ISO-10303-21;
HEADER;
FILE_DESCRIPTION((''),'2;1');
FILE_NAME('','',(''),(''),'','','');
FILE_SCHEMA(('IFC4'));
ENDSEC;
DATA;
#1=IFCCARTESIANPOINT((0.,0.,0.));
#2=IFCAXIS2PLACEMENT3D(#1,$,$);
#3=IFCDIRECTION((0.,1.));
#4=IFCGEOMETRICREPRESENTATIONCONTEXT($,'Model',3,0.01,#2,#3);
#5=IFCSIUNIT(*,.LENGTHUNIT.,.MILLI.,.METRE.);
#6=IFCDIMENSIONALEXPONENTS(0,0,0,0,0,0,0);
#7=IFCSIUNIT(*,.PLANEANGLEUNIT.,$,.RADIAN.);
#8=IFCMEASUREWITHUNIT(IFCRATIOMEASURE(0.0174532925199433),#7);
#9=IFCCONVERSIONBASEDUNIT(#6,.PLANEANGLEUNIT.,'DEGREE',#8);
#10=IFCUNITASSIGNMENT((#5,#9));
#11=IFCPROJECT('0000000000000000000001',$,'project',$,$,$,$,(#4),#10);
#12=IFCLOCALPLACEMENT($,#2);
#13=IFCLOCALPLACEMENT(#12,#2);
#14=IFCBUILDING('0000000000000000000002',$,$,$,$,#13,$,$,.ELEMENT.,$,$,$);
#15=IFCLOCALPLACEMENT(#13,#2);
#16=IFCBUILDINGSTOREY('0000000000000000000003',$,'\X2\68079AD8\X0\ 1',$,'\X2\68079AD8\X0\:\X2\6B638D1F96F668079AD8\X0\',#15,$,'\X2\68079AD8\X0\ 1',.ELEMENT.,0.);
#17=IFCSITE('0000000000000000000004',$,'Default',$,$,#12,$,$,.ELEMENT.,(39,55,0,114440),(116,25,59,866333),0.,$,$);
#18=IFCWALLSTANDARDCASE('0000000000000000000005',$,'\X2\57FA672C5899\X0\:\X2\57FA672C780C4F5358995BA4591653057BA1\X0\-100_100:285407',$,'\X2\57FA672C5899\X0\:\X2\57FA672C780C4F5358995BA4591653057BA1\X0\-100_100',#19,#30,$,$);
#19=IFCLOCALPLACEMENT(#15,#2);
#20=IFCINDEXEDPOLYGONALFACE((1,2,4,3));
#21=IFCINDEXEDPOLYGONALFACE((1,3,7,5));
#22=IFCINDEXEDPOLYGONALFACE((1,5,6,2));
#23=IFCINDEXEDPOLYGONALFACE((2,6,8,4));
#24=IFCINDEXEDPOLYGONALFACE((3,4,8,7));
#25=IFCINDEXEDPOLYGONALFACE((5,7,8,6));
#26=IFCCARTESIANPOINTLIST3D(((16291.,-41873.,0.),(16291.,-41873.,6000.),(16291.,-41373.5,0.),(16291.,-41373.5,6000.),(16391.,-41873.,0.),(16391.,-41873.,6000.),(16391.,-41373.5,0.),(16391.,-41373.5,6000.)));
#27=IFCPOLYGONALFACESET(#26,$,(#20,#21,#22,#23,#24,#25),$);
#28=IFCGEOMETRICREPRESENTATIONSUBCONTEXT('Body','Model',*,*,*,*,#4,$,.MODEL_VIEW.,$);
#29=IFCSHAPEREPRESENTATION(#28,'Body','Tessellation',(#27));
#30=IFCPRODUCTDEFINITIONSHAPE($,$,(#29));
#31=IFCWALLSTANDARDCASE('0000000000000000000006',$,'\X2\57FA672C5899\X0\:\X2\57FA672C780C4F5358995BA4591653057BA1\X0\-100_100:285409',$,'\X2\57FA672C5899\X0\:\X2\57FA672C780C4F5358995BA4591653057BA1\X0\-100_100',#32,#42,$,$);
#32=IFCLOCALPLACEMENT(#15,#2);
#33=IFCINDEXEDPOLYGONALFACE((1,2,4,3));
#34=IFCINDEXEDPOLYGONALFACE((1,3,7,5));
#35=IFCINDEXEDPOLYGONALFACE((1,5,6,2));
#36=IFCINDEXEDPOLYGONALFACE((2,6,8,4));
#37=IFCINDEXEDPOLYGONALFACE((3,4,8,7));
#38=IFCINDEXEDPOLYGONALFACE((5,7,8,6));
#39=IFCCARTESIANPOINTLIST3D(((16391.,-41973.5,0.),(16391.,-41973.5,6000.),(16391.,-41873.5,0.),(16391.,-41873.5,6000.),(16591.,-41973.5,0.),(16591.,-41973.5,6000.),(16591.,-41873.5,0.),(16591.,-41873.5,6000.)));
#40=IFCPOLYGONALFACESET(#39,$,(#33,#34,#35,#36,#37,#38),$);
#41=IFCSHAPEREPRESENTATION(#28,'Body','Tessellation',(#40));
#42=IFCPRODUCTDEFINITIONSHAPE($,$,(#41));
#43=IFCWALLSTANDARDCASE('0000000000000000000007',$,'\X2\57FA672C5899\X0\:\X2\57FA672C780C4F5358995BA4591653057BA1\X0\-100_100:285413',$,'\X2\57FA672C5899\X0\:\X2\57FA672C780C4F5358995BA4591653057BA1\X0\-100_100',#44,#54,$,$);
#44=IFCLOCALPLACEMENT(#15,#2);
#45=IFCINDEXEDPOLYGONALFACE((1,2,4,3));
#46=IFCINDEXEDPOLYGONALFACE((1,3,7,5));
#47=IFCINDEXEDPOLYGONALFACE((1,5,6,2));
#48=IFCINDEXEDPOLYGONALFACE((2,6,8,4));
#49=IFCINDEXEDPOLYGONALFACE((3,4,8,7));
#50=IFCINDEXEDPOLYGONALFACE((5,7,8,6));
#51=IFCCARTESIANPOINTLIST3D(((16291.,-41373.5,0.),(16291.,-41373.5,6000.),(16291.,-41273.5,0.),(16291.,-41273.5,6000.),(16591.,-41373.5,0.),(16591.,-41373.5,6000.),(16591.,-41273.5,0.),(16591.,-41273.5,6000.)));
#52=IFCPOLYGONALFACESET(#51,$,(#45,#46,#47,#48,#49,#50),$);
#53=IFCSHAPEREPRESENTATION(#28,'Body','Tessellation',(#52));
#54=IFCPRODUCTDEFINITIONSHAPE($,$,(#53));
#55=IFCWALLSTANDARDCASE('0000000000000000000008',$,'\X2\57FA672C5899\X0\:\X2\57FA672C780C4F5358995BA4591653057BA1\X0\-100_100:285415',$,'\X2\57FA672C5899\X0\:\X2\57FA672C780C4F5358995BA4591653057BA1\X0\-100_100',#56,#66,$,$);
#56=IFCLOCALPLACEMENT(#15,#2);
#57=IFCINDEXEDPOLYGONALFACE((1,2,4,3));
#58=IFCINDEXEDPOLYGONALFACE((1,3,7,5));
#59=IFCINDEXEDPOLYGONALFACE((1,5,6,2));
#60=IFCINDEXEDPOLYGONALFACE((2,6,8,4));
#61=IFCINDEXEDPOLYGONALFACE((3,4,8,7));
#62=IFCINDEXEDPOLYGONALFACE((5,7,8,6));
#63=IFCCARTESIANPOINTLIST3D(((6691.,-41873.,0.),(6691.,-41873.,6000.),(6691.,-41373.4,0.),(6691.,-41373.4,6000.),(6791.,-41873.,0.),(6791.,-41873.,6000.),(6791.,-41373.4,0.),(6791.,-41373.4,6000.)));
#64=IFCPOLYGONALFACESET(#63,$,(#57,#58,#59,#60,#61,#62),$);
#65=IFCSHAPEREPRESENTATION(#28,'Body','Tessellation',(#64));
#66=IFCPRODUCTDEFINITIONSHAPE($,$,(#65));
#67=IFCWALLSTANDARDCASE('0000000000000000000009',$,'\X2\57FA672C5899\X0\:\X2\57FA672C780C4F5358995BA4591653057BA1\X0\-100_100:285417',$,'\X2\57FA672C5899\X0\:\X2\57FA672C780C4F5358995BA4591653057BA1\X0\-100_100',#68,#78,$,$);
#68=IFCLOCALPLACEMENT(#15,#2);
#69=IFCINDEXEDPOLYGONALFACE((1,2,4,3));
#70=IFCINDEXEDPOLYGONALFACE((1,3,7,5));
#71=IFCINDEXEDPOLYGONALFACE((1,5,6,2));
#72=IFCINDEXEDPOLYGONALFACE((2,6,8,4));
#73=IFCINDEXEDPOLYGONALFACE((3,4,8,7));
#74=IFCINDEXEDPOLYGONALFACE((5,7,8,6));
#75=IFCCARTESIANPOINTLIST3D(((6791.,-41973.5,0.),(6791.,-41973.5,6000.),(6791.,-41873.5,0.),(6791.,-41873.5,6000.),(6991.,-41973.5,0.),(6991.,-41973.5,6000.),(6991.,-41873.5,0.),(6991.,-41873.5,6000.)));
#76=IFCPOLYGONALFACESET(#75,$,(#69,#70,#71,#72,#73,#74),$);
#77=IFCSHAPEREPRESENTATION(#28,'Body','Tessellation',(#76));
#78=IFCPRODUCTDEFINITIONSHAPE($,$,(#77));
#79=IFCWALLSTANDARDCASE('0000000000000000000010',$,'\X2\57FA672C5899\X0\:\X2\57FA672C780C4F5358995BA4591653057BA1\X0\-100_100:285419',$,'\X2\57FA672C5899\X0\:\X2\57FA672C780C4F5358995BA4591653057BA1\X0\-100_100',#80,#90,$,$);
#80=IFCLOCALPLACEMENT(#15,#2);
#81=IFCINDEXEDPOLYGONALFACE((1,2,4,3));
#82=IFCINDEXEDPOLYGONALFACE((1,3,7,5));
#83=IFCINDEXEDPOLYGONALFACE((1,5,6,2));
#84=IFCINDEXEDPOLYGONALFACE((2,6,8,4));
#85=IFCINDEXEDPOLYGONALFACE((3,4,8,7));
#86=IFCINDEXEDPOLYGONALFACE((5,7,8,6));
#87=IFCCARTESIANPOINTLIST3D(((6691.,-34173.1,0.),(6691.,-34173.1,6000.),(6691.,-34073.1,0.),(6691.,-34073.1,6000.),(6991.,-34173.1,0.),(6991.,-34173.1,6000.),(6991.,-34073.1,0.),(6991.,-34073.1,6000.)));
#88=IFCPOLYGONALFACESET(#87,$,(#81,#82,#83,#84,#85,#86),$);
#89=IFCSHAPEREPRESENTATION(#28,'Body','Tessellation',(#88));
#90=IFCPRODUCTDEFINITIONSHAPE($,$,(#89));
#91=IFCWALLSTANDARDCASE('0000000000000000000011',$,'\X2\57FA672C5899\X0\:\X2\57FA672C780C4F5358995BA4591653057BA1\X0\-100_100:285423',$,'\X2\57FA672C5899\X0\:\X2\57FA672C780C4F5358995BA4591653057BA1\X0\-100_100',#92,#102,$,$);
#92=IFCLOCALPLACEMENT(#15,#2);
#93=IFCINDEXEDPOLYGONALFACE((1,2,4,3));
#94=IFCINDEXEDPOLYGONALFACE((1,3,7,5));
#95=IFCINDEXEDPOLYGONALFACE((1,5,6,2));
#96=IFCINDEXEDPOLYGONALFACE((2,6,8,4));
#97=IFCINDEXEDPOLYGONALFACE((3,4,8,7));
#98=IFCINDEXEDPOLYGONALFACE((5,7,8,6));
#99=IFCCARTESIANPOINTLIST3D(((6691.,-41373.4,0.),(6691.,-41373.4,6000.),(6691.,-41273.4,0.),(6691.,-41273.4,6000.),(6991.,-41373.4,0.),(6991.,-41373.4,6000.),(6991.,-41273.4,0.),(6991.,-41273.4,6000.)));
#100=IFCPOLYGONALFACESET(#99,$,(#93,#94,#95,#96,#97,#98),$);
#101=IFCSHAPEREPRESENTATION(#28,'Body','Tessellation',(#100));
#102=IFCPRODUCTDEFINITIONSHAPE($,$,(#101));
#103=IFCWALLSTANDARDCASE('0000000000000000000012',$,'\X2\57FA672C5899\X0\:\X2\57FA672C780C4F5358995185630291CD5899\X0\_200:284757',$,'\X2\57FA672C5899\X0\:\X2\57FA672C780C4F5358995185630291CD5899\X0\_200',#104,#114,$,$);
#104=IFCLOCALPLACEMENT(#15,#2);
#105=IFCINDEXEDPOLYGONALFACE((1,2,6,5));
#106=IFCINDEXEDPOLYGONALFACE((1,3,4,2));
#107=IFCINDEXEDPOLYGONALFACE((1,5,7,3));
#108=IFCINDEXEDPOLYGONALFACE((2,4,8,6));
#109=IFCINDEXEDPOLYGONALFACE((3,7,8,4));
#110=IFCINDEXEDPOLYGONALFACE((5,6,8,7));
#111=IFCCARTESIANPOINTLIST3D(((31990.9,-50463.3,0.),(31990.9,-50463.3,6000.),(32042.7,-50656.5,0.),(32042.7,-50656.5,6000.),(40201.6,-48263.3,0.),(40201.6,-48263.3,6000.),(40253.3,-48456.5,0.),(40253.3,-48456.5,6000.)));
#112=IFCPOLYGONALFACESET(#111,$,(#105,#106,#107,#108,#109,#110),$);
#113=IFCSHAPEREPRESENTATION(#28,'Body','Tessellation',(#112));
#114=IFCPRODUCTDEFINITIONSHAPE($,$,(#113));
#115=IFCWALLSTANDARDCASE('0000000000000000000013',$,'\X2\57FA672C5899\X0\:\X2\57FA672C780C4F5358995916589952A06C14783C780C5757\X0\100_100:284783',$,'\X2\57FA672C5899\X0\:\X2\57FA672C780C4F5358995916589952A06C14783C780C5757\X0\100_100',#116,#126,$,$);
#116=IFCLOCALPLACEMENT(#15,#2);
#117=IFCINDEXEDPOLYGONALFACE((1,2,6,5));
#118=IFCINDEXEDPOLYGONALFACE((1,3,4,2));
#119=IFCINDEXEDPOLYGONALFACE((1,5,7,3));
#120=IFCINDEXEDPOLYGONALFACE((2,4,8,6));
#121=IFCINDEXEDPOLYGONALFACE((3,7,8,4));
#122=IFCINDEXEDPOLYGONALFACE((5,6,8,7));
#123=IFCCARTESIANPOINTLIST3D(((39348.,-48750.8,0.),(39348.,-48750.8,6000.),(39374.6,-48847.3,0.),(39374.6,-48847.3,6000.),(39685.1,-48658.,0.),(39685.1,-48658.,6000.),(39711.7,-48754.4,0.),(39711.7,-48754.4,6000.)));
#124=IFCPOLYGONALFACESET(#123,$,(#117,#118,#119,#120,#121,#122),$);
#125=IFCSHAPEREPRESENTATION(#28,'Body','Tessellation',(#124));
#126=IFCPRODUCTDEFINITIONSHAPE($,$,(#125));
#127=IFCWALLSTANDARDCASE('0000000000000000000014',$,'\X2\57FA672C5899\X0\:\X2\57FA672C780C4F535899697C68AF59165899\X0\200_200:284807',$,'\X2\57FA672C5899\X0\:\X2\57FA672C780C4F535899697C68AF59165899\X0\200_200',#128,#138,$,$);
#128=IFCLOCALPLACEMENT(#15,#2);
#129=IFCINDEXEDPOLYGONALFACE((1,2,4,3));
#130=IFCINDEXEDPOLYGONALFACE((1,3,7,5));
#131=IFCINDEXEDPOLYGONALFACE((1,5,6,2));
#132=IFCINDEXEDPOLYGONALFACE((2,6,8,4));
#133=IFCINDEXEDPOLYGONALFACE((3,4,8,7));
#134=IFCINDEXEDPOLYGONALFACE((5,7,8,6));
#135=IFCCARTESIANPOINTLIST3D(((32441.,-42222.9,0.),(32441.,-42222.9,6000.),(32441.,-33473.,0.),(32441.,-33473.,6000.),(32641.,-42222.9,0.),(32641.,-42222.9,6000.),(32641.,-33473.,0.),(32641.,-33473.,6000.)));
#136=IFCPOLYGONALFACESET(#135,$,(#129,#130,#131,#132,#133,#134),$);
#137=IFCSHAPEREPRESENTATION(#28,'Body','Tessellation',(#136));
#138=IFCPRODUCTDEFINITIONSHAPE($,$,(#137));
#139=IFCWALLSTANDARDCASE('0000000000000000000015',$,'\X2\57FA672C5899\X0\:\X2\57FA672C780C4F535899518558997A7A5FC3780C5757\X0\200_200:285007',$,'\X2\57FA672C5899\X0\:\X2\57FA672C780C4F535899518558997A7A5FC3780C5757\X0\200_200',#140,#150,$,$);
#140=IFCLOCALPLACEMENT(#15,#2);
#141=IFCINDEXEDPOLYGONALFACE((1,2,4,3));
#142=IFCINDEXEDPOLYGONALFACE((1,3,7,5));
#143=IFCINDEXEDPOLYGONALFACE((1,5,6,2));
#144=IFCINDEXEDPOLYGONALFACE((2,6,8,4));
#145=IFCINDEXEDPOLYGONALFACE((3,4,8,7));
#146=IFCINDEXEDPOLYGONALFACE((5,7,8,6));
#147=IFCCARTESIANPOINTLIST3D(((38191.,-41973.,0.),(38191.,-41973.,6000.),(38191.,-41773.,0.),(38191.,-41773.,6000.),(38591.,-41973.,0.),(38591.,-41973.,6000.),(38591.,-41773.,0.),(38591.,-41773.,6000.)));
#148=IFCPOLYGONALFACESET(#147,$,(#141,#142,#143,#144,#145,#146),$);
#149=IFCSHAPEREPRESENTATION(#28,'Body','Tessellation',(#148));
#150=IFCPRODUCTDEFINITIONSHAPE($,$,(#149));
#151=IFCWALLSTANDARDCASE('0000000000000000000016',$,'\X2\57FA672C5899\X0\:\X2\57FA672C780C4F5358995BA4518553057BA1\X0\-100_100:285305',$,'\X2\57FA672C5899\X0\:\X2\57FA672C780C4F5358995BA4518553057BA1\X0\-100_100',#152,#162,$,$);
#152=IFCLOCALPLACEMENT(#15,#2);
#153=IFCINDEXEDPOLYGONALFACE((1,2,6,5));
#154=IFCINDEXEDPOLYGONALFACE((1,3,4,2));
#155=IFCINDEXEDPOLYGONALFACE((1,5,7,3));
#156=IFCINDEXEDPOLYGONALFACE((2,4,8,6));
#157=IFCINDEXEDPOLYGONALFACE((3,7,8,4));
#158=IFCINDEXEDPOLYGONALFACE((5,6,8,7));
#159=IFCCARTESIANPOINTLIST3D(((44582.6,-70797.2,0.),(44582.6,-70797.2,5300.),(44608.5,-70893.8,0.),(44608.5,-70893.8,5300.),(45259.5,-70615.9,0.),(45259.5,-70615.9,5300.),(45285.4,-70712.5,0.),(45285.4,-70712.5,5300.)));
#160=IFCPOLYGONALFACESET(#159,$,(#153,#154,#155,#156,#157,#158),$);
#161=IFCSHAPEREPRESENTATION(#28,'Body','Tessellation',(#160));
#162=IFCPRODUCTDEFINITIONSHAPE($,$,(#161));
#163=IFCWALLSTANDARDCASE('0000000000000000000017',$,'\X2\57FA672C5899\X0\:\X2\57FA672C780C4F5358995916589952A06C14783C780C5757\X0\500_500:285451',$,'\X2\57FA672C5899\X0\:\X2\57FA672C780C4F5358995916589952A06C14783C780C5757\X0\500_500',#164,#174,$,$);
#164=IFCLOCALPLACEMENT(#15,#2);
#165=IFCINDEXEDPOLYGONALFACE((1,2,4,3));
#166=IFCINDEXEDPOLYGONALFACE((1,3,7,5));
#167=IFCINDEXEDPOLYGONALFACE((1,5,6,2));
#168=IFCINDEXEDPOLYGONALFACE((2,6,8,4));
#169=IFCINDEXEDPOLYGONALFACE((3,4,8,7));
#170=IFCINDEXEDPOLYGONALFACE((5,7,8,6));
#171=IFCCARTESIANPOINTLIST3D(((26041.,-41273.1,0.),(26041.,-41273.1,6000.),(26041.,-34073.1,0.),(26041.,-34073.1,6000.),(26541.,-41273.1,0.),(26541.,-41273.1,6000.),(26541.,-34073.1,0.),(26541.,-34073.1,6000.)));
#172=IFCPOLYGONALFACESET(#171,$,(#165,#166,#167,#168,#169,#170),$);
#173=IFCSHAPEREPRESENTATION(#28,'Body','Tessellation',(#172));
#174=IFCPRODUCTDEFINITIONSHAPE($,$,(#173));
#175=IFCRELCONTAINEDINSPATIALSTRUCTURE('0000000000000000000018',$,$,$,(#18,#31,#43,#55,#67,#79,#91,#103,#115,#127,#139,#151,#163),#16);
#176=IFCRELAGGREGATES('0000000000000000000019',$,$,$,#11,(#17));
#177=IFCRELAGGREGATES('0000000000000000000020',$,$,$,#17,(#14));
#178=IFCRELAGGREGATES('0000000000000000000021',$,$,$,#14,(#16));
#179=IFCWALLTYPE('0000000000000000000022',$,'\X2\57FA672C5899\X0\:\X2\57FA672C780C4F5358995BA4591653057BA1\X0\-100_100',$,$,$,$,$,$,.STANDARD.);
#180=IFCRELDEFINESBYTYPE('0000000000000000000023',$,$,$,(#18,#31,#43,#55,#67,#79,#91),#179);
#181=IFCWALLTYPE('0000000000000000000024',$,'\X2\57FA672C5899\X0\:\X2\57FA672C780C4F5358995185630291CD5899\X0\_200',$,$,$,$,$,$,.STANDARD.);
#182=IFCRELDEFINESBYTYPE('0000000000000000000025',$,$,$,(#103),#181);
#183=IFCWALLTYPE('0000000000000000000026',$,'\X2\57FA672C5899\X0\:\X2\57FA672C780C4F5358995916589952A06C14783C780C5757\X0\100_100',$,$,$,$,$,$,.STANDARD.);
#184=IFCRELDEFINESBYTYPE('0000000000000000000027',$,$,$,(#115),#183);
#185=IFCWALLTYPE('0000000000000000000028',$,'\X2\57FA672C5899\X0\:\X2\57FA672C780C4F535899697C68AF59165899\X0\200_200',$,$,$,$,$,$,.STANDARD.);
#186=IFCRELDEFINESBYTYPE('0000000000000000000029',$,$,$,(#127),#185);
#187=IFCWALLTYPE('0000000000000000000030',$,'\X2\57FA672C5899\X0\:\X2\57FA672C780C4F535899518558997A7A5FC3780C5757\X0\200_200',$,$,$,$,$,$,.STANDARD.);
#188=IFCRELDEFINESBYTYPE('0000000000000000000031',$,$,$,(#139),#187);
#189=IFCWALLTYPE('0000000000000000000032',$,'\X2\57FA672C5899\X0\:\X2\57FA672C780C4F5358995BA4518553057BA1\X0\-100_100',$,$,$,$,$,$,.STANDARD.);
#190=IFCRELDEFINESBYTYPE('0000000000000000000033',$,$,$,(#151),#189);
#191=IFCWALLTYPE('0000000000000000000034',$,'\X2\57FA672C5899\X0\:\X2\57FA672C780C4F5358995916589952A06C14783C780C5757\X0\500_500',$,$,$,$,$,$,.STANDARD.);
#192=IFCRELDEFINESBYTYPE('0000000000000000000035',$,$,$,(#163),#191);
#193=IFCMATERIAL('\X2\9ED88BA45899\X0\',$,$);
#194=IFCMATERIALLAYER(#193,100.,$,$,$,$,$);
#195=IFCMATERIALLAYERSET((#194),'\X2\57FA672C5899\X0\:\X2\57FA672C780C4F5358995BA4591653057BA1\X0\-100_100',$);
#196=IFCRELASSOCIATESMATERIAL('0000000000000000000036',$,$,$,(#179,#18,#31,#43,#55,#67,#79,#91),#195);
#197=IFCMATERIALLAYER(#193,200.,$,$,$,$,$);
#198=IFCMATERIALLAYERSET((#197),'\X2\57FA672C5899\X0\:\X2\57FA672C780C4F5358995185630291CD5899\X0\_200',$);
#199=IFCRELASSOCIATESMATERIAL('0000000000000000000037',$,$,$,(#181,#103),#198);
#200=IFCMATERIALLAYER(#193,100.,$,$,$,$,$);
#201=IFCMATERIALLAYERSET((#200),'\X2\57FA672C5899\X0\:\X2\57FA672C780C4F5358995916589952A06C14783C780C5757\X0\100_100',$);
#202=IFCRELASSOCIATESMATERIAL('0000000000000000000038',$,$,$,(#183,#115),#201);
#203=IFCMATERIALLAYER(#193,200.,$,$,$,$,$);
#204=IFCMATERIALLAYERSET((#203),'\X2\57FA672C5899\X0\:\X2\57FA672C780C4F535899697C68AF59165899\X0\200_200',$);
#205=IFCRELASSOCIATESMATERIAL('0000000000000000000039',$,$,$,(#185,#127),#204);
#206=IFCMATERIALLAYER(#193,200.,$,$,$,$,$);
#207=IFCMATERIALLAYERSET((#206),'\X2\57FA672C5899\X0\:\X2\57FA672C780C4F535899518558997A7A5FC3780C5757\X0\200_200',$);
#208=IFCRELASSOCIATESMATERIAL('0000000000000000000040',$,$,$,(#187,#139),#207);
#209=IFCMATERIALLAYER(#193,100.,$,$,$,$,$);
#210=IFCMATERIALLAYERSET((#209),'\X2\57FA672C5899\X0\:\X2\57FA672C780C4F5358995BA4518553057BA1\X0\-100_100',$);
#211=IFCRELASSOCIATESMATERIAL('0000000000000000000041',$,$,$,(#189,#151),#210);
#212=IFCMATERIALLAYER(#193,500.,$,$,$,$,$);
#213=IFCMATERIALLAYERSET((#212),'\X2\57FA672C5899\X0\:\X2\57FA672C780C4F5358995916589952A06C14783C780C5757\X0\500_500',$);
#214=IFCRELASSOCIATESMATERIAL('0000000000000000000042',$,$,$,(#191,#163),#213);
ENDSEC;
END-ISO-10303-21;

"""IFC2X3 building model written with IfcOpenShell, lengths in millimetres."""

from ifc_helpers import new_model, entity, si_unit, converted_unit, direction, frame, frame_2d, origin, place, context, subcontext, project, spatial, rectangle, extrude, material, layer, layer_set, layer_usage, type_object, element, save


model = new_model("IFC2X3")

# Units and contexts
model_context = context("Model", 3, precision=0.01, world=origin(), true_north=direction((0.0, 1.0)))
body_context = subcontext(model_context, "Body", "Model", "MODEL_VIEW")
ifc_project = project(units=[si_unit("LENGTHUNIT", "METRE", prefix="MILLI"), converted_unit("PLANEANGLEUNIT", "DEGREE", entity("IfcRatioMeasure", 0.0174532925199433), si_unit("PLANEANGLEUNIT", "RADIAN"), dimensions=[0, 0, 0, 0, 0, 0, 0])], contexts=[model_context])

# Site, building, storey
site_placement = place(None, origin())
site = spatial("IfcSite", under=ifc_project, at=site_placement, Name="Default", CompositionType="ELEMENT", RefLatitude=(39, 55, 0, 114440), RefLongitude=(116, 25, 59, 866333), RefElevation=0.0)
building_placement = place(site_placement, origin())
building = spatial("IfcBuilding", under=site, at=building_placement, CompositionType="ELEMENT")
storey_placement = place(building_placement, origin())
storey = spatial("IfcBuildingStorey", under=building, at=storey_placement, Name="标高 1", ObjectType="标高:正负零标高", LongName="标高 1", CompositionType="ELEMENT", Elevation=0.0)

# Walls
ifc_material = material(Name="默认墙")
ifc_layer_1 = layer(ifc_material, 100.0)
ifc_layer_set_1 = layer_set([ifc_layer_1], Name="基本墙:基本砌体墙室外包管-100_100")
wall_type_1 = type_object("IfcWallType", Name="基本墙:基本砌体墙室外包管-100_100", PredefinedType="STANDARD", material=ifc_layer_set_1)
ifc_layer_usage_1 = layer_usage(ifc_layer_set_1, "AXIS2", "NEGATIVE", 50.0)
wall_1_placement = place(building_placement, frame((16341.0, -41373.5, 0.0), z_axis=(0.0, 0.0, 1.0), x_axis=(0.0, -1.0, 0.0)))
element("IfcWallStandardCase", 1, at=wall_1_placement, inside=storey, type_object=wall_type_1, material=ifc_layer_usage_1, Name="基本墙:基本砌体墙室外包管-100_100:285407", ObjectType="基本墙:基本砌体墙室外包管-100_100", context=body_context, shape_type="SweptSolid", body=[
    extrude(rectangle(XDim=499.5, YDim=100.0, at=frame_2d((249.8, 0.0), x_axis=(-1.0, 0.0))), origin(), (0.0, 0.0, 1.0), 6000.0),
])
ifc_layer_usage_2 = layer_usage(ifc_layer_set_1, "AXIS2", "NEGATIVE", 50.0)
wall_2_placement = place(building_placement, frame((16391.0, -41923.5, 0.0)))
element("IfcWallStandardCase", 2, at=wall_2_placement, inside=storey, type_object=wall_type_1, material=ifc_layer_usage_2, Name="基本墙:基本砌体墙室外包管-100_100:285409", ObjectType="基本墙:基本砌体墙室外包管-100_100", context=body_context, shape_type="SweptSolid", body=[
    extrude(rectangle(XDim=200.0, YDim=100.0, at=frame_2d((100.0, 0.0), x_axis=(-1.0, 0.0))), origin(), (0.0, 0.0, 1.0), 6000.0),
])
ifc_layer_usage_3 = layer_usage(ifc_layer_set_1, "AXIS2", "NEGATIVE", 50.0)
wall_3_placement = place(building_placement, frame((16291.0, -41323.5, 0.0)))
element("IfcWallStandardCase", 3, at=wall_3_placement, inside=storey, type_object=wall_type_1, material=ifc_layer_usage_3, Name="基本墙:基本砌体墙室外包管-100_100:285413", ObjectType="基本墙:基本砌体墙室外包管-100_100", context=body_context, shape_type="SweptSolid", body=[
    extrude(rectangle(XDim=300.0, YDim=100.0, at=frame_2d((150.0, 0.0), x_axis=(-1.0, 0.0))), origin(), (0.0, 0.0, 1.0), 6000.0),
])
ifc_layer_usage_4 = layer_usage(ifc_layer_set_1, "AXIS2", "NEGATIVE", 50.0)
wall_4_placement = place(building_placement, frame((6741.0, -41373.4, 0.0), z_axis=(0.0, 0.0, 1.0), x_axis=(0.0, -1.0, 0.0)))
element("IfcWallStandardCase", 4, at=wall_4_placement, inside=storey, type_object=wall_type_1, material=ifc_layer_usage_4, Name="基本墙:基本砌体墙室外包管-100_100:285415", ObjectType="基本墙:基本砌体墙室外包管-100_100", context=body_context, shape_type="SweptSolid", body=[
    extrude(rectangle(XDim=499.6, YDim=100.0, at=frame_2d((249.8, 0.0), x_axis=(-1.0, 0.0))), origin(), (0.0, 0.0, 1.0), 6000.0),
])
ifc_layer_usage_5 = layer_usage(ifc_layer_set_1, "AXIS2", "NEGATIVE", 50.0)
wall_5_placement = place(building_placement, frame((6791.0, -41923.5, 0.0)))
element("IfcWallStandardCase", 5, at=wall_5_placement, inside=storey, type_object=wall_type_1, material=ifc_layer_usage_5, Name="基本墙:基本砌体墙室外包管-100_100:285417", ObjectType="基本墙:基本砌体墙室外包管-100_100", context=body_context, shape_type="SweptSolid", body=[
    extrude(rectangle(XDim=200.0, YDim=100.0, at=frame_2d((100.0, 0.0), x_axis=(-1.0, 0.0))), origin(), (0.0, 0.0, 1.0), 6000.0),
])
ifc_layer_usage_6 = layer_usage(ifc_layer_set_1, "AXIS2", "NEGATIVE", 50.0)
wall_6_placement = place(building_placement, frame((6691.0, -34123.1, 0.0)))
element("IfcWallStandardCase", 6, at=wall_6_placement, inside=storey, type_object=wall_type_1, material=ifc_layer_usage_6, Name="基本墙:基本砌体墙室外包管-100_100:285419", ObjectType="基本墙:基本砌体墙室外包管-100_100", context=body_context, shape_type="SweptSolid", body=[
    extrude(rectangle(XDim=300.0, YDim=100.0, at=frame_2d((150.0, 0.0), x_axis=(-1.0, 0.0))), origin(), (0.0, 0.0, 1.0), 6000.0),
])
ifc_layer_usage_7 = layer_usage(ifc_layer_set_1, "AXIS2", "NEGATIVE", 50.0)
wall_7_placement = place(building_placement, frame((6691.0, -41323.4, 0.0)))
element("IfcWallStandardCase", 7, at=wall_7_placement, inside=storey, type_object=wall_type_1, material=ifc_layer_usage_7, Name="基本墙:基本砌体墙室外包管-100_100:285423", ObjectType="基本墙:基本砌体墙室外包管-100_100", context=body_context, shape_type="SweptSolid", body=[
    extrude(rectangle(XDim=300.0, YDim=100.0, at=frame_2d((150.0, 0.0), x_axis=(-1.0, 0.0))), origin(), (0.0, 0.0, 1.0), 6000.0),
])
ifc_layer_2 = layer(ifc_material, 200.0)
ifc_layer_set_2 = layer_set([ifc_layer_2], Name="基本墙:基本砌体墙内挂重墙_200")
ifc_layer_usage_8 = layer_usage(ifc_layer_set_2, "AXIS2", "NEGATIVE", 100.0)
wall_type_2 = type_object("IfcWallType", Name="基本墙:基本砌体墙内挂重墙_200", PredefinedType="STANDARD", material=ifc_layer_set_2)
wall_8_placement = place(building_placement, frame((32016.8, -50559.9, 0.0), z_axis=(0.0, 0.0, 1.0), x_axis=(0.965926, 0.258819, 0.0)))
element("IfcWallStandardCase", 8, at=wall_8_placement, inside=storey, type_object=wall_type_2, material=ifc_layer_usage_8, Name="基本墙:基本砌体墙内挂重墙_200:284757", ObjectType="基本墙:基本砌体墙内挂重墙_200", context=body_context, shape_type="SweptSolid", body=[
    extrude(rectangle(XDim=8500.3, YDim=200.0, at=frame_2d((4250.1, 0.0), x_axis=(-1.0, 0.0))), origin(), (0.0, 0.0, 1.0), 6000.0),
])
ifc_layer_3 = layer(ifc_material, 100.0)
ifc_layer_set_3 = layer_set([ifc_layer_3], Name="基本墙:基本砌体墙外墙加气砼砌块100_100")
ifc_layer_usage_9 = layer_usage(ifc_layer_set_3, "AXIS2", "NEGATIVE", 50.0)
wall_type_3 = type_object("IfcWallType", Name="基本墙:基本砌体墙外墙加气砼砌块100_100", PredefinedType="STANDARD", material=ifc_layer_set_3)
wall_9_placement = place(building_placement, frame((39361.3, -48799.0, 0.0), z_axis=(0.0, 0.0, 1.0), x_axis=(0.964054, 0.265705, 0.0)))
element("IfcWallStandardCase", 9, at=wall_9_placement, inside=storey, type_object=wall_type_3, material=ifc_layer_usage_9, Name="基本墙:基本砌体墙外墙加气砼砌块100_100:284783", ObjectType="基本墙:基本砌体墙外墙加气砼砌块100_100", context=body_context, shape_type="SweptSolid", body=[
    extrude(rectangle(XDim=349.6, YDim=100.0, at=frame_2d((174.8, 0.0), x_axis=(-1.0, 0.0))), origin(), (0.0, 0.0, 1.0), 6000.0),
])
ifc_layer_4 = layer(ifc_material, 200.0)
ifc_layer_set_4 = layer_set([ifc_layer_4], Name="基本墙:基本砌体墙楼梯外墙200_200")
ifc_layer_usage_10 = layer_usage(ifc_layer_set_4, "AXIS2", "NEGATIVE", 100.0)
wall_type_4 = type_object("IfcWallType", Name="基本墙:基本砌体墙楼梯外墙200_200", PredefinedType="STANDARD", material=ifc_layer_set_4)
wall_10_placement = place(building_placement, frame((32541.0, -42222.9, 0.0), z_axis=(0.0, 0.0, 1.0), x_axis=(0.0, 1.0, 0.0)))
element("IfcWallStandardCase", 10, at=wall_10_placement, inside=storey, type_object=wall_type_4, material=ifc_layer_usage_10, Name="基本墙:基本砌体墙楼梯外墙200_200:284807", ObjectType="基本墙:基本砌体墙楼梯外墙200_200", context=body_context, shape_type="SweptSolid", body=[
    extrude(rectangle(XDim=8749.9, YDim=200.0, at=frame_2d((4374.9, 0.0), x_axis=(-1.0, 0.0))), origin(), (0.0, 0.0, 1.0), 6000.0),
])
ifc_layer_5 = layer(ifc_material, 200.0)
ifc_layer_set_5 = layer_set([ifc_layer_5], Name="基本墙:基本砌体墙内墙空心砌块200_200")
ifc_layer_usage_11 = layer_usage(ifc_layer_set_5, "AXIS2", "NEGATIVE", 100.0)
wall_type_5 = type_object("IfcWallType", Name="基本墙:基本砌体墙内墙空心砌块200_200", PredefinedType="STANDARD", material=ifc_layer_set_5)
wall_11_placement = place(building_placement, frame((38191.0, -41873.0, 0.0)))
element("IfcWallStandardCase", 11, at=wall_11_placement, inside=storey, type_object=wall_type_5, material=ifc_layer_usage_11, Name="基本墙:基本砌体墙内墙空心砌块200_200:285007", ObjectType="基本墙:基本砌体墙内墙空心砌块200_200", context=body_context, shape_type="SweptSolid", body=[
    extrude(rectangle(XDim=400.0, YDim=200.0, at=frame_2d((200.0, 0.0), x_axis=(-1.0, 0.0))), origin(), (0.0, 0.0, 1.0), 6000.0),
])
ifc_layer_6 = layer(ifc_material, 100.0)
ifc_layer_set_6 = layer_set([ifc_layer_6], Name="基本墙:基本砌体墙室内包管-100_100")
ifc_layer_usage_12 = layer_usage(ifc_layer_set_6, "AXIS2", "NEGATIVE", 50.0)
wall_type_6 = type_object("IfcWallType", Name="基本墙:基本砌体墙室内包管-100_100", PredefinedType="STANDARD", material=ifc_layer_set_6)
wall_12_placement = place(building_placement, frame((44595.6, -70845.5, 0.0), z_axis=(0.0, 0.0, 1.0), x_axis=(0.965926, 0.258819, 0.0)))
element("IfcWallStandardCase", 12, at=wall_12_placement, inside=storey, type_object=wall_type_6, material=ifc_layer_usage_12, Name="基本墙:基本砌体墙室内包管-100_100:285305", ObjectType="基本墙:基本砌体墙室内包管-100_100", context=body_context, shape_type="SweptSolid", body=[
    extrude(rectangle(XDim=700.7, YDim=100.0, at=frame_2d((350.4, 0.0), x_axis=(-1.0, 0.0))), origin(), (0.0, 0.0, 1.0), 5300.0),
])
ifc_layer_7 = layer(ifc_material, 500.0)
ifc_layer_set_7 = layer_set([ifc_layer_7], Name="基本墙:基本砌体墙外墙加气砼砌块500_500")
ifc_layer_usage_13 = layer_usage(ifc_layer_set_7, "AXIS2", "NEGATIVE", 250.0)
wall_type_7 = type_object("IfcWallType", Name="基本墙:基本砌体墙外墙加气砼砌块500_500", PredefinedType="STANDARD", material=ifc_layer_set_7)
wall_13_placement = place(building_placement, frame((26291.0, -41273.1, 0.0), z_axis=(0.0, 0.0, 1.0), x_axis=(0.0, 1.0, 0.0)))
element("IfcWallStandardCase", 13, at=wall_13_placement, inside=storey, type_object=wall_type_7, material=ifc_layer_usage_13, Name="基本墙:基本砌体墙外墙加气砼砌块500_500:285451", ObjectType="基本墙:基本砌体墙外墙加气砼砌块500_500", context=body_context, shape_type="SweptSolid", body=[
    extrude(rectangle(XDim=7200.0, YDim=500.0, at=frame_2d((3600.0, 0.0), x_axis=(-1.0, 0.0))), origin(), (0.0, 0.0, 1.0), 6000.0),
])

save(model, "model.ifc")
